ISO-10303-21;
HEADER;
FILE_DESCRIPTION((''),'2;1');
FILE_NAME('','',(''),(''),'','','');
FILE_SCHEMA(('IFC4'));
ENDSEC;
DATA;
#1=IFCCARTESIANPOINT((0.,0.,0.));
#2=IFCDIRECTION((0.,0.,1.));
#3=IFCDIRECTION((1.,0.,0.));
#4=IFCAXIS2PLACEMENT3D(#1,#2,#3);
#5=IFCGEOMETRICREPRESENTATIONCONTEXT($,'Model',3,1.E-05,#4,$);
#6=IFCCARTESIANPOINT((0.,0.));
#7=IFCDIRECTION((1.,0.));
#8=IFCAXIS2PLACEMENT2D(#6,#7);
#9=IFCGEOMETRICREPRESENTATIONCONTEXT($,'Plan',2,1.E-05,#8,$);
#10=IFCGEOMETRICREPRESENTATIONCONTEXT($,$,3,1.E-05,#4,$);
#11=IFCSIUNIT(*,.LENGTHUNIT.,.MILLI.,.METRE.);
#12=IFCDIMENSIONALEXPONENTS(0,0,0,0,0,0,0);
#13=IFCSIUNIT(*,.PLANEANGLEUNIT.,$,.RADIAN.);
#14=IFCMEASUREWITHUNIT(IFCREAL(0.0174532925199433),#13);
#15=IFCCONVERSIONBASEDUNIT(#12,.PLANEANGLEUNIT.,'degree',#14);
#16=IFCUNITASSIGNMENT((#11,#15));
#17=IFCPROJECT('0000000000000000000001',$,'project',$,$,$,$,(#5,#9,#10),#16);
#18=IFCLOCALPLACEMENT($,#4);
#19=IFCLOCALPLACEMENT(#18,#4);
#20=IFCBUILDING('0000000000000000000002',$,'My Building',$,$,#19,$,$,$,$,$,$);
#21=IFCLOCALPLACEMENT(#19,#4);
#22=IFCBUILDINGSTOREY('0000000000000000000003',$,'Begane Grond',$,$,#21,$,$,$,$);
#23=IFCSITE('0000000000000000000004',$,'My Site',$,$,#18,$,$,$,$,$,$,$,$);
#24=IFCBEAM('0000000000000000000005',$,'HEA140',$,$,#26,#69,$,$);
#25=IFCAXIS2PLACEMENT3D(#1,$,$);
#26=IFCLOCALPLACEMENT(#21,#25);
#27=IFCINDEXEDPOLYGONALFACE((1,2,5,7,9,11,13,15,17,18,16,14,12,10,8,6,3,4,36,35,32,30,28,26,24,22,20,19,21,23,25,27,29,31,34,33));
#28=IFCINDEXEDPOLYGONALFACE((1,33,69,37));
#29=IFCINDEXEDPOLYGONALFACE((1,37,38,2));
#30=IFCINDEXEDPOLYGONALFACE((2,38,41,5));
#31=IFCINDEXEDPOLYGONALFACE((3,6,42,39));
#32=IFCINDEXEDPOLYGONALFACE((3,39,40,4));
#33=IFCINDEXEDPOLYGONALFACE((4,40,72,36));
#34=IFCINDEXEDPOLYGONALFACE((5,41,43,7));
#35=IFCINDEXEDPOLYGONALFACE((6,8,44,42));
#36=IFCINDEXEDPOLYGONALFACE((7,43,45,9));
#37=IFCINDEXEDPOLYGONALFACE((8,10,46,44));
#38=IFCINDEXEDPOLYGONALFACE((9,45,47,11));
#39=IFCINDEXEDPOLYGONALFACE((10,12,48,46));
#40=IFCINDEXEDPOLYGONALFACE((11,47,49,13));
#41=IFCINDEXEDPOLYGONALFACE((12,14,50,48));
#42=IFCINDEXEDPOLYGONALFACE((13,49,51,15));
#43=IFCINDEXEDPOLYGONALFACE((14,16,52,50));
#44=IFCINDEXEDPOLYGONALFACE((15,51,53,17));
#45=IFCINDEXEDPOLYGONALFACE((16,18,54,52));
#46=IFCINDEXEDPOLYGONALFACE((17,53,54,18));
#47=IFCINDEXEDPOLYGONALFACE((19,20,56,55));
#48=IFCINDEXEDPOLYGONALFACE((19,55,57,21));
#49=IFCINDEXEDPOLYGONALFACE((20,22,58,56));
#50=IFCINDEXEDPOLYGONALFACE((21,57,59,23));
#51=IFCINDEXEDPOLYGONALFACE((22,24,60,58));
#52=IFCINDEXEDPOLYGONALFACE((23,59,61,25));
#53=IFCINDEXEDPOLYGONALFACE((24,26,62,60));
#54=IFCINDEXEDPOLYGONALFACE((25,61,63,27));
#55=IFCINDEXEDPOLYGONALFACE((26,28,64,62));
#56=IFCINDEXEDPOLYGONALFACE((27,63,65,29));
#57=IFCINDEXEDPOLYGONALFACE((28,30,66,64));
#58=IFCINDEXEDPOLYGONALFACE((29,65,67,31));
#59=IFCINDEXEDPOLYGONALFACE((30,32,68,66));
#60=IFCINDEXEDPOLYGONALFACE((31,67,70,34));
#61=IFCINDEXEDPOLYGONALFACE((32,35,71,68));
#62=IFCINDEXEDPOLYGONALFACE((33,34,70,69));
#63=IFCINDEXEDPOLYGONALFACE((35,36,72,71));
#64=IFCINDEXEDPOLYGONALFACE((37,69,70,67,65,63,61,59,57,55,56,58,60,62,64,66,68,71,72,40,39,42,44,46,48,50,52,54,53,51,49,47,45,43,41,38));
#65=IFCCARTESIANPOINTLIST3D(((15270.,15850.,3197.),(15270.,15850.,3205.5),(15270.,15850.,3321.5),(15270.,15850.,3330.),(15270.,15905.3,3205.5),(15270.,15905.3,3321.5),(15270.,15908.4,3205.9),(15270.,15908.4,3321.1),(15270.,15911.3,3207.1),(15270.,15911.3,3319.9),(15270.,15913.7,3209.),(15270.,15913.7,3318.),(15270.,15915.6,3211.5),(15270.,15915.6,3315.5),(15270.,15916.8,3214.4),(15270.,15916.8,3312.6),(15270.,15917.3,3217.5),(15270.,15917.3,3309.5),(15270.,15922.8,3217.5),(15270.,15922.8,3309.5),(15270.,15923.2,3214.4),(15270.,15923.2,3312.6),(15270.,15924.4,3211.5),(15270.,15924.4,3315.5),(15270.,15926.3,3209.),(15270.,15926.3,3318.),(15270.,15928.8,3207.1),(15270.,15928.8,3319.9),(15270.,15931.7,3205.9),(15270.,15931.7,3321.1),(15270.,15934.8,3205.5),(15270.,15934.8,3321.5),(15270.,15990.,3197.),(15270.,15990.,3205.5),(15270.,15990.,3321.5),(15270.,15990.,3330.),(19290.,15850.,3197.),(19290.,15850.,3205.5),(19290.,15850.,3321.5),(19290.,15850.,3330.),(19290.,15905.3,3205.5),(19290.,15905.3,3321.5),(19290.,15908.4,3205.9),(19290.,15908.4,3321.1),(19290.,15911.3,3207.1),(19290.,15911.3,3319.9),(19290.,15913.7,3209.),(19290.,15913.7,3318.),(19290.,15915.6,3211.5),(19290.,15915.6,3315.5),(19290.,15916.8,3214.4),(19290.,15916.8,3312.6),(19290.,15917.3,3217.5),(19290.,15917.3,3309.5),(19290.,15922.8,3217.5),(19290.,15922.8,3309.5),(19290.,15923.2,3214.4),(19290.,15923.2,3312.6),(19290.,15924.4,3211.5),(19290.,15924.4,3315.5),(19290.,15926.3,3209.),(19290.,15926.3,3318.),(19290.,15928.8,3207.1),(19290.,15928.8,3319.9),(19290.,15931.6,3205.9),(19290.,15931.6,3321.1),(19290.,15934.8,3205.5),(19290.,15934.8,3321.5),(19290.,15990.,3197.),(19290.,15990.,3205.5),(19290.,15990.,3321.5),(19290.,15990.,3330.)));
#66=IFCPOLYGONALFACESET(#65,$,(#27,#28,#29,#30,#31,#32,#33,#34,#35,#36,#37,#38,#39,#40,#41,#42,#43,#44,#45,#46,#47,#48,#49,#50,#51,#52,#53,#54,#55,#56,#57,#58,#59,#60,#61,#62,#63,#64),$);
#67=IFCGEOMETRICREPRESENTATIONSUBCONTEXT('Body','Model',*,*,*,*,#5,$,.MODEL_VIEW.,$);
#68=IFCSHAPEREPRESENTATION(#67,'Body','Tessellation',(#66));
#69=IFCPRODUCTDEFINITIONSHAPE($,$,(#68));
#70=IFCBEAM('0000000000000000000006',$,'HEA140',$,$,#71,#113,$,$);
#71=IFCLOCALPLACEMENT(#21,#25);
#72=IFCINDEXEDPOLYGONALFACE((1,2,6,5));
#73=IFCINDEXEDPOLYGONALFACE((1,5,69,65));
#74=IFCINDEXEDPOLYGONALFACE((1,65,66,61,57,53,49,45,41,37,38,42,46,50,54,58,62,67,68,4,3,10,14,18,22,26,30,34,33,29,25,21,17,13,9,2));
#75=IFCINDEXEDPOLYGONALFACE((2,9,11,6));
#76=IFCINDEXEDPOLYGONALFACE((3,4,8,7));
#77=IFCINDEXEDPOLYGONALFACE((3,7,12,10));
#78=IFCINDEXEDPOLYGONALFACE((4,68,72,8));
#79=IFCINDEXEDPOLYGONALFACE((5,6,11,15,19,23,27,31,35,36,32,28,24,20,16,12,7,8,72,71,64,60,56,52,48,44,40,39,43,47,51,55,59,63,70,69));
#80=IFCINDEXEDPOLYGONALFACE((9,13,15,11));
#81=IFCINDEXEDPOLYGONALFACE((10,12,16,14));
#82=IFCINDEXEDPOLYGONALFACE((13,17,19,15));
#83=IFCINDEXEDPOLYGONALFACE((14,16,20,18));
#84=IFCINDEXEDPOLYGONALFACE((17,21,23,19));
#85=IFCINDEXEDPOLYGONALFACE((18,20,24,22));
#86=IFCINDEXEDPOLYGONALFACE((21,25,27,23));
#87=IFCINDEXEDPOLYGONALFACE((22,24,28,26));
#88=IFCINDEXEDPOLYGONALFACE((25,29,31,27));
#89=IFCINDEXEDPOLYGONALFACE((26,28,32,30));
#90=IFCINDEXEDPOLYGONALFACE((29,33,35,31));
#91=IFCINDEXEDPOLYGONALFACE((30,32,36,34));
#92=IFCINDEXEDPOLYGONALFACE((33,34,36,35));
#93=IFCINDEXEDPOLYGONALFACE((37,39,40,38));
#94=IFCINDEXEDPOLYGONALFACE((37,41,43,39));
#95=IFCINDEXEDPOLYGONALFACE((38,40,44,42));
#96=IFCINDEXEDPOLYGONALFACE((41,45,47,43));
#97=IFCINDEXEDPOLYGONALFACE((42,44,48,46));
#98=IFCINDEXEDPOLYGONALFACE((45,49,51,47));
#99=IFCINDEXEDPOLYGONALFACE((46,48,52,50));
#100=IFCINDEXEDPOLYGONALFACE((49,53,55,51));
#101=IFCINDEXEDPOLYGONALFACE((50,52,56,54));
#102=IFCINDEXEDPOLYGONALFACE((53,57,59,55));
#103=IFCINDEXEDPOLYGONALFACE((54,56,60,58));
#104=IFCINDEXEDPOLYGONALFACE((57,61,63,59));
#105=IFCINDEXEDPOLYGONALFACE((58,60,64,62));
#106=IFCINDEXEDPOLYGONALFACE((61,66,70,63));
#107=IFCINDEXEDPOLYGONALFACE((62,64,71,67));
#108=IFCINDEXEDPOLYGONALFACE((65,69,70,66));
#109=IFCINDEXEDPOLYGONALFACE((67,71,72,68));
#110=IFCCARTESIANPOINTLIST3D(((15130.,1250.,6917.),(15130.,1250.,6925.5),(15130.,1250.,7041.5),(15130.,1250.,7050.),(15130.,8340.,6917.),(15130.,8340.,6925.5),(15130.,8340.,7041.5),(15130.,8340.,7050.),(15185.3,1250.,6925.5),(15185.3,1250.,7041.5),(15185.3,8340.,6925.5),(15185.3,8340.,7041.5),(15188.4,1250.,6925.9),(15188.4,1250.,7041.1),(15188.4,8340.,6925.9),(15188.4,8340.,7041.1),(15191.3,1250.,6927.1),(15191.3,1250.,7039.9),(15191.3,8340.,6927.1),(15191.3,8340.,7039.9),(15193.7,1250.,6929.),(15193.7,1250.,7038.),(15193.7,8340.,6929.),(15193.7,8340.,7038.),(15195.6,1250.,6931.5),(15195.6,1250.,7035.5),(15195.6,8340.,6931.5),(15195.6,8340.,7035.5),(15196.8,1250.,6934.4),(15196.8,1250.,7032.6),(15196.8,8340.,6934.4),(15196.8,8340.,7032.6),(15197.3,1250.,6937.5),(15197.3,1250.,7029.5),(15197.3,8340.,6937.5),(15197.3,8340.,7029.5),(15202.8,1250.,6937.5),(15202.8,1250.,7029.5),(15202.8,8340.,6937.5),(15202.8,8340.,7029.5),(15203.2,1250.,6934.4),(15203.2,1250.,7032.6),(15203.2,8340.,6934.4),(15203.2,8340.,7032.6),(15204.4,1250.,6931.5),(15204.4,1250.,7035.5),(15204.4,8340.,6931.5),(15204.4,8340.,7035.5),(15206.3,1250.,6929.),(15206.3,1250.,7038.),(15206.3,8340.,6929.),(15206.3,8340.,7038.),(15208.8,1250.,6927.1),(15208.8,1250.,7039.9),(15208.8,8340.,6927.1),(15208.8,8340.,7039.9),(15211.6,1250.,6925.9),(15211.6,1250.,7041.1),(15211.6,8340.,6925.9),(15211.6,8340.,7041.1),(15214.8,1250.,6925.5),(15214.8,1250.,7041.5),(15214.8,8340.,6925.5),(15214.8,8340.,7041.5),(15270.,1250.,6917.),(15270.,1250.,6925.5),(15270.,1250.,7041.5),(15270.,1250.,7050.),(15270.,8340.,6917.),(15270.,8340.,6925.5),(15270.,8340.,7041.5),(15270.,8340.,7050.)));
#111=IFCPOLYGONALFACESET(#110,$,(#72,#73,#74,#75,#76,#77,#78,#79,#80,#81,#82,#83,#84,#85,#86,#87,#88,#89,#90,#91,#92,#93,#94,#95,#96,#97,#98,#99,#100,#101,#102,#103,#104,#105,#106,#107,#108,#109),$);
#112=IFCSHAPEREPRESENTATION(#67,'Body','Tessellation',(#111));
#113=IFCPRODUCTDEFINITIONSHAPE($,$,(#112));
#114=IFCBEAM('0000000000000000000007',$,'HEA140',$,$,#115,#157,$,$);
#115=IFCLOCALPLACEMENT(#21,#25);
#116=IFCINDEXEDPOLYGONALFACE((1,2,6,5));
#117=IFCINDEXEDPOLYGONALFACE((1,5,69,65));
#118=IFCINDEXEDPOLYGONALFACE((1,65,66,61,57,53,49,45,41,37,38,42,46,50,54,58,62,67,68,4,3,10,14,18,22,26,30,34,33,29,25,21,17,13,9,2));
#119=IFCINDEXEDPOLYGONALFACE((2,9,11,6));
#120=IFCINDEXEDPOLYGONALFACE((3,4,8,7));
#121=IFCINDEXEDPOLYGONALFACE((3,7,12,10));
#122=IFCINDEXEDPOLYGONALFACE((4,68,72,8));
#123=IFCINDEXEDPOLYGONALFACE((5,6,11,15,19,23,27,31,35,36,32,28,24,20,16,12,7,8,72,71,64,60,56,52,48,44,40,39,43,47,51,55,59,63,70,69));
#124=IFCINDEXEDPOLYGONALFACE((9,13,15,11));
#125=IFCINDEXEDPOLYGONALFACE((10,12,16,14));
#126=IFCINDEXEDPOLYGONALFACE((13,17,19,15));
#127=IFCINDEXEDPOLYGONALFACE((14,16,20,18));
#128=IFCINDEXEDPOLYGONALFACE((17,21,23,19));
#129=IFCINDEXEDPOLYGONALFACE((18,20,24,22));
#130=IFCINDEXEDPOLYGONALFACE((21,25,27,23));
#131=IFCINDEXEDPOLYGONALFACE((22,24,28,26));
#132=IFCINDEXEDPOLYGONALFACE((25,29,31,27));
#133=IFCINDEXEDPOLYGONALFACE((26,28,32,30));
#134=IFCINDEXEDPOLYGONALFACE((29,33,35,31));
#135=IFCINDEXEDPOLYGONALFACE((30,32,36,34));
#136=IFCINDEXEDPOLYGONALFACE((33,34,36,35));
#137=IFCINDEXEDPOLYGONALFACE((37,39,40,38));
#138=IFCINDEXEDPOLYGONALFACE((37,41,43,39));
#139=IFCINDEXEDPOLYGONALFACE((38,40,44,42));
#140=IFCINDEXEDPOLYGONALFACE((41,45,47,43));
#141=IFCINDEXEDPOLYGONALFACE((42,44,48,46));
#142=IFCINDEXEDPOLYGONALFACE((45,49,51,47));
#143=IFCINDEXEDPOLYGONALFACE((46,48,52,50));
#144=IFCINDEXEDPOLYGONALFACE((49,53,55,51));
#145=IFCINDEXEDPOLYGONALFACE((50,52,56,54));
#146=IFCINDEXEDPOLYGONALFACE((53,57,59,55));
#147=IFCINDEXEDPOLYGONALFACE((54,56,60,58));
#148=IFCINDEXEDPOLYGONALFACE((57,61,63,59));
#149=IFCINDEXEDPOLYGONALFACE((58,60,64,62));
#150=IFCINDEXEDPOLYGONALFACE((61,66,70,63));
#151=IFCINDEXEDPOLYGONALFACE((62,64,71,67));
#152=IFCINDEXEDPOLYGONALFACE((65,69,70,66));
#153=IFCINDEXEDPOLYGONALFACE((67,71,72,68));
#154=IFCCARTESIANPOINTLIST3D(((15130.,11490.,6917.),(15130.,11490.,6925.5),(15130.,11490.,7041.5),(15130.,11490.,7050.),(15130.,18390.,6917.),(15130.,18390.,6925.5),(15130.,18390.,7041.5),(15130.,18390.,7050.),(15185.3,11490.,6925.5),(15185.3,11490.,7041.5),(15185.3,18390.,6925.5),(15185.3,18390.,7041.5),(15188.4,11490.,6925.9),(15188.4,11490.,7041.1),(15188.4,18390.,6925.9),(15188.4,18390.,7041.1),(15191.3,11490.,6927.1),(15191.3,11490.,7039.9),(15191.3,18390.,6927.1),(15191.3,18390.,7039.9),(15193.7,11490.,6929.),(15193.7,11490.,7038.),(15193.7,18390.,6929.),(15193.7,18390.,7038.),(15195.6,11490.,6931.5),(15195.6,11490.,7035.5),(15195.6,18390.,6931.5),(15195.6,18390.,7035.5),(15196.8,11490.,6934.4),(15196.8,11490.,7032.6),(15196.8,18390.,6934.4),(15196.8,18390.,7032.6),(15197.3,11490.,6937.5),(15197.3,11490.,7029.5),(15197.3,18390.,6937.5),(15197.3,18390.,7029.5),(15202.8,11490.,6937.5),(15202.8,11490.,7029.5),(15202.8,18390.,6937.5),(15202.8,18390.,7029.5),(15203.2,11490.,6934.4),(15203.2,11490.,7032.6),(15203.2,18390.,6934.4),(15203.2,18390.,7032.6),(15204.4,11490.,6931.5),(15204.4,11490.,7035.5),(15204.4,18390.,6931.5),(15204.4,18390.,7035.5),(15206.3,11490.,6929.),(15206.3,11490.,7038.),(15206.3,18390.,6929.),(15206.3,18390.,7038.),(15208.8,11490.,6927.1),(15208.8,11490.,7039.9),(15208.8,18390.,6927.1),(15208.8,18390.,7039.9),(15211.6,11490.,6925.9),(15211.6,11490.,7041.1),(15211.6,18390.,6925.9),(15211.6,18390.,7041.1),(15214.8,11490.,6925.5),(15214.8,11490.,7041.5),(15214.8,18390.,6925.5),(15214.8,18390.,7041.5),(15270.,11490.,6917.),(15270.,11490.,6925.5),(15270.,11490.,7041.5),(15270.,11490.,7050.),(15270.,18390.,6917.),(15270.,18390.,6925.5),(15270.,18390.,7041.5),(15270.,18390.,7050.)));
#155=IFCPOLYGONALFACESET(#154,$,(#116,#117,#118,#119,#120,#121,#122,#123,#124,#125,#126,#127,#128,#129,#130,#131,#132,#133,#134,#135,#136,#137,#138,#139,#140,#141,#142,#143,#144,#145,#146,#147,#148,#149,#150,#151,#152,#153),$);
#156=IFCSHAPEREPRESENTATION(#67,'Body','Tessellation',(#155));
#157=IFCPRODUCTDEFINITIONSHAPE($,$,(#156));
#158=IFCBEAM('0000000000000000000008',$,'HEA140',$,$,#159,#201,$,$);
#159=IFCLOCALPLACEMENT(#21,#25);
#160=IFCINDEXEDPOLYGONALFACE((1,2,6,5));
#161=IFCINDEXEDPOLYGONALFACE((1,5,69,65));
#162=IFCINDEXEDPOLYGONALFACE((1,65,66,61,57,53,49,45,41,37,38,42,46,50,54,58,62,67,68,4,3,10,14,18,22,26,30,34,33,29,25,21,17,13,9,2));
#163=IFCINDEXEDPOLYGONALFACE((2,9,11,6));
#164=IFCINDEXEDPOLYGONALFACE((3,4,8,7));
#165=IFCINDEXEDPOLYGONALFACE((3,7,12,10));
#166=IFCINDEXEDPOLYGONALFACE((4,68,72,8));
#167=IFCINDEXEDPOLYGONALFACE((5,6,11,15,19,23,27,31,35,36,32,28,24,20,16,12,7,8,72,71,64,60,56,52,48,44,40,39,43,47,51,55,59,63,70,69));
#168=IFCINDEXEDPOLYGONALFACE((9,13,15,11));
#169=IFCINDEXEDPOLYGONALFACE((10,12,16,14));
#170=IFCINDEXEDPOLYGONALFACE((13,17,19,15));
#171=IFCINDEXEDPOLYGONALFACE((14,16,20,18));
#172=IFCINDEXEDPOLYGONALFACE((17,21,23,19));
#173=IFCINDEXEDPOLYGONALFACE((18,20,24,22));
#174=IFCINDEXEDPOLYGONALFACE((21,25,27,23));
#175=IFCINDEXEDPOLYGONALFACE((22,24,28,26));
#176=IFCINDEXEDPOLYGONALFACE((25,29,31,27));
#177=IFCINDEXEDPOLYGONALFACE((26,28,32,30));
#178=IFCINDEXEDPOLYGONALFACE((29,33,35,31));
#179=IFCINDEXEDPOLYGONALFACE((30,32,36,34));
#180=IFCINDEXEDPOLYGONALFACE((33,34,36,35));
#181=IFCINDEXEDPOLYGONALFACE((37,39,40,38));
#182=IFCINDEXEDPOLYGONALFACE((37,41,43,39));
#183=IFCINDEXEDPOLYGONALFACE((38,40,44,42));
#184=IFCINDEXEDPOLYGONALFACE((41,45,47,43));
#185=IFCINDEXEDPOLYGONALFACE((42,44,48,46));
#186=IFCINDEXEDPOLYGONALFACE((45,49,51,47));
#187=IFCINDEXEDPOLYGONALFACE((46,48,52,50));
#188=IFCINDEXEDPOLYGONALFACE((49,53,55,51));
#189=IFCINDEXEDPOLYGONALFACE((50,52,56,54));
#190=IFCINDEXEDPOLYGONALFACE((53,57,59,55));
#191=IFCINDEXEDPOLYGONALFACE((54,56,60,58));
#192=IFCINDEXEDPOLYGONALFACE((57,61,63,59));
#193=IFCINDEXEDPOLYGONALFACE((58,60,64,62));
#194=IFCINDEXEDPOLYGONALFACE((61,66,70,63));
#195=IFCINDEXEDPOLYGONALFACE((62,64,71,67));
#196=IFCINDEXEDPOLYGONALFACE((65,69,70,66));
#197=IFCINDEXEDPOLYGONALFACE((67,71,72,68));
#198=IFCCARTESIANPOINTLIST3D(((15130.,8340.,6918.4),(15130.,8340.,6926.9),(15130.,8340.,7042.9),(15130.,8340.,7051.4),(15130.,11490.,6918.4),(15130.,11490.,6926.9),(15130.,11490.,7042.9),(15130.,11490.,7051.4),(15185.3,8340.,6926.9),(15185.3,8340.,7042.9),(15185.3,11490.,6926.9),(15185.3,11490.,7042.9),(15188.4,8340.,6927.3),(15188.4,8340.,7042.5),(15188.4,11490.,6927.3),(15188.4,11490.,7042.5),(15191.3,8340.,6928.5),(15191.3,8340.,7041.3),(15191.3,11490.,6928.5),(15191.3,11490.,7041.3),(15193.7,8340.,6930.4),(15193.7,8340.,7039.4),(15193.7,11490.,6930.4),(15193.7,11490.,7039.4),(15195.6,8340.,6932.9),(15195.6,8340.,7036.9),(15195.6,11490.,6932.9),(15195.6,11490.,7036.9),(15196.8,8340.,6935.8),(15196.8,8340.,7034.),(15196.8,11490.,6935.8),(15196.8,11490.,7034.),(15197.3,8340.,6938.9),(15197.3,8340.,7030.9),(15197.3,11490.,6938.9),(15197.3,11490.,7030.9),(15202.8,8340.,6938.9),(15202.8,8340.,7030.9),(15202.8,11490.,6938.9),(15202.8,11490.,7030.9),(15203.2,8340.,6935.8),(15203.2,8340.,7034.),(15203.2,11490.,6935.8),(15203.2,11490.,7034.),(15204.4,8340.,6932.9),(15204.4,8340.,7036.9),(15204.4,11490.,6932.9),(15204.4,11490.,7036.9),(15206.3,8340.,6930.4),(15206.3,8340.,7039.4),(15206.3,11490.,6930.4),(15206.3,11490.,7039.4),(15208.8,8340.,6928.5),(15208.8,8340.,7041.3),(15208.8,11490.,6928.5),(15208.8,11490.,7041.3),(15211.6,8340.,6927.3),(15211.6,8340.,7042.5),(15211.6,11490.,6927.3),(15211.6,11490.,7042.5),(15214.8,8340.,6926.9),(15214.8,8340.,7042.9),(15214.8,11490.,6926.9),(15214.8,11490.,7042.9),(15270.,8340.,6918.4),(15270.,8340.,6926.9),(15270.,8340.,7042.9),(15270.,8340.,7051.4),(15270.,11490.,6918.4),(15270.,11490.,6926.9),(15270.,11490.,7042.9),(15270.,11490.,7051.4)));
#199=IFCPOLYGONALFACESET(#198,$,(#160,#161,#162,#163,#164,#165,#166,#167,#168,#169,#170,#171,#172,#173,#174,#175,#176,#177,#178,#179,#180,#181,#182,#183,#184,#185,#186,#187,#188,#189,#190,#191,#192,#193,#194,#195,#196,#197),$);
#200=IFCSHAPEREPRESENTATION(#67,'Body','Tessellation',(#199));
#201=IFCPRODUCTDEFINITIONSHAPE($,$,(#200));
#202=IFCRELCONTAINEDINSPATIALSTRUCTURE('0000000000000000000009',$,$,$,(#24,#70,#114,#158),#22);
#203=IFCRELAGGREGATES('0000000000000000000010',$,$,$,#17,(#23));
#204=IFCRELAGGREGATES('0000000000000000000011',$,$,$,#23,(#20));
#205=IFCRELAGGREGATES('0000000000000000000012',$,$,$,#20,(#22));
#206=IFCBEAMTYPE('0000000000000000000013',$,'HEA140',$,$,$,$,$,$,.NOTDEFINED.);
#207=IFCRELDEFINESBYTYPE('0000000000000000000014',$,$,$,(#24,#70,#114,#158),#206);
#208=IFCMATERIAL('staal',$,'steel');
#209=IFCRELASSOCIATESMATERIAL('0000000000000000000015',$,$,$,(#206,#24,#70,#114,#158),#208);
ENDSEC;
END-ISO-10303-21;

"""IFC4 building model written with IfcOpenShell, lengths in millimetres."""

from ifc_helpers import new_model, entity, si_unit, converted_unit, frame, origin_with_axes, origin_2d_with_axis, place, context, subcontext, project, spatial, i_section, extrude, material, material_profile, profile_set, profile_usage, type_object, element, save


model = new_model("IFC4")

# Units and contexts
model_context = context("Model", 3, precision=1e-05, world=origin_with_axes())
plan_context = context("Plan", 2, precision=1e-05, world=origin_2d_with_axis())
context_of_model = context(None, 3, precision=1e-05, world=origin_with_axes())
body_context = subcontext(model_context, "Body", "Model", "MODEL_VIEW")
ifc_project = project(units=[si_unit("LENGTHUNIT", "METRE", prefix="MILLI"), converted_unit("PLANEANGLEUNIT", "degree", entity("IfcReal", 0.0174532925199433), si_unit("PLANEANGLEUNIT", "RADIAN"), dimensions=[0, 0, 0, 0, 0, 0, 0])], contexts=[model_context, plan_context, context_of_model])

# Site, building, storey
site_placement = place(None, origin_with_axes())
site = spatial("IfcSite", under=ifc_project, at=site_placement, Name="My Site")
building_placement = place(site_placement, origin_with_axes())
building = spatial("IfcBuilding", under=site, at=building_placement, Name="My Building")
storey_placement = place(building_placement, origin_with_axes())
storey = spatial("IfcBuildingStorey", under=building, at=storey_placement, Name="Begane Grond")

# Shared definitions
ifc_material = material(Name="staal", Category="steel")

# Beams
ifc_material_profile_1 = material_profile(ifc_material, i_section(OverallWidth=140.0, OverallDepth=133.0, WebThickness=5.5, FlangeThickness=8.5, FilletRadius=12.0))
ifc_profile_set_1 = profile_set([ifc_material_profile_1], Name="HEA140")
beam_type_1 = type_object("IfcBeamType", Name="HEA140", PredefinedType="NOTDEFINED", material=ifc_profile_set_1)
ifc_profile_usage_1 = profile_usage(ifc_profile_set_1)
beam_1_placement = place(storey_placement, frame((19290.0, 15920.0, 3263.5), z_axis=(-1.0, 0.0, 0.0), x_axis=(0.0, -1.0, 0.0)))
element("IfcBeam", 1, at=beam_1_placement, inside=storey, type_object=beam_type_1, material=ifc_profile_usage_1, Name="HEA140", context=body_context, shape_type="SweptSolid", body=[
    extrude(i_section(OverallWidth=140.0, OverallDepth=133.0, WebThickness=5.5, FlangeThickness=8.5, FilletRadius=12.0), origin_with_axes(), (0.0, 0.0, 1.0), 4020.0),
])
ifc_profile_usage_2 = profile_usage(ifc_profile_set_1)
beam_2_placement = place(storey_placement, frame((15200.0, 1250.0, 6983.5), z_axis=(0.0, 1.0, 0.0), x_axis=(-1.0, 0.0, 0.0)))
element("IfcBeam", 2, at=beam_2_placement, inside=storey, type_object=beam_type_1, material=ifc_profile_usage_2, Name="HEA140", context=body_context, shape_type="SweptSolid", body=[
    extrude(i_section(OverallWidth=140.0, OverallDepth=133.0, WebThickness=5.5, FlangeThickness=8.5, FilletRadius=12.0), origin_with_axes(), (0.0, 0.0, 1.0), 7090.0),
])
ifc_profile_usage_3 = profile_usage(ifc_profile_set_1)
beam_3_placement = place(storey_placement, frame((15200.0, 11490.0, 6983.5), z_axis=(0.0, 1.0, 0.0), x_axis=(-1.0, 0.0, 0.0)))
element("IfcBeam", 3, at=beam_3_placement, inside=storey, type_object=beam_type_1, material=ifc_profile_usage_3, Name="HEA140", context=body_context, shape_type="SweptSolid", body=[
    extrude(i_section(OverallWidth=140.0, OverallDepth=133.0, WebThickness=5.5, FlangeThickness=8.5, FilletRadius=12.0), origin_with_axes(), (0.0, 0.0, 1.0), 6900.0),
])
ifc_profile_usage_4 = profile_usage(ifc_profile_set_1)
beam_4_placement = place(storey_placement, frame((15200.0, 8340.0, 6984.9), z_axis=(0.0, 1.0, 0.0), x_axis=(-1.0, 0.0, 0.0)))
element("IfcBeam", 4, at=beam_4_placement, inside=storey, type_object=beam_type_1, material=ifc_profile_usage_4, Name="HEA140", context=body_context, shape_type="SweptSolid", body=[
    extrude(i_section(OverallWidth=140.0, OverallDepth=133.0, WebThickness=5.5, FlangeThickness=8.5, FilletRadius=12.0), origin_with_axes(), (0.0, 0.0, 1.0), 3150.0),
])

save(model, "model.ifc")
